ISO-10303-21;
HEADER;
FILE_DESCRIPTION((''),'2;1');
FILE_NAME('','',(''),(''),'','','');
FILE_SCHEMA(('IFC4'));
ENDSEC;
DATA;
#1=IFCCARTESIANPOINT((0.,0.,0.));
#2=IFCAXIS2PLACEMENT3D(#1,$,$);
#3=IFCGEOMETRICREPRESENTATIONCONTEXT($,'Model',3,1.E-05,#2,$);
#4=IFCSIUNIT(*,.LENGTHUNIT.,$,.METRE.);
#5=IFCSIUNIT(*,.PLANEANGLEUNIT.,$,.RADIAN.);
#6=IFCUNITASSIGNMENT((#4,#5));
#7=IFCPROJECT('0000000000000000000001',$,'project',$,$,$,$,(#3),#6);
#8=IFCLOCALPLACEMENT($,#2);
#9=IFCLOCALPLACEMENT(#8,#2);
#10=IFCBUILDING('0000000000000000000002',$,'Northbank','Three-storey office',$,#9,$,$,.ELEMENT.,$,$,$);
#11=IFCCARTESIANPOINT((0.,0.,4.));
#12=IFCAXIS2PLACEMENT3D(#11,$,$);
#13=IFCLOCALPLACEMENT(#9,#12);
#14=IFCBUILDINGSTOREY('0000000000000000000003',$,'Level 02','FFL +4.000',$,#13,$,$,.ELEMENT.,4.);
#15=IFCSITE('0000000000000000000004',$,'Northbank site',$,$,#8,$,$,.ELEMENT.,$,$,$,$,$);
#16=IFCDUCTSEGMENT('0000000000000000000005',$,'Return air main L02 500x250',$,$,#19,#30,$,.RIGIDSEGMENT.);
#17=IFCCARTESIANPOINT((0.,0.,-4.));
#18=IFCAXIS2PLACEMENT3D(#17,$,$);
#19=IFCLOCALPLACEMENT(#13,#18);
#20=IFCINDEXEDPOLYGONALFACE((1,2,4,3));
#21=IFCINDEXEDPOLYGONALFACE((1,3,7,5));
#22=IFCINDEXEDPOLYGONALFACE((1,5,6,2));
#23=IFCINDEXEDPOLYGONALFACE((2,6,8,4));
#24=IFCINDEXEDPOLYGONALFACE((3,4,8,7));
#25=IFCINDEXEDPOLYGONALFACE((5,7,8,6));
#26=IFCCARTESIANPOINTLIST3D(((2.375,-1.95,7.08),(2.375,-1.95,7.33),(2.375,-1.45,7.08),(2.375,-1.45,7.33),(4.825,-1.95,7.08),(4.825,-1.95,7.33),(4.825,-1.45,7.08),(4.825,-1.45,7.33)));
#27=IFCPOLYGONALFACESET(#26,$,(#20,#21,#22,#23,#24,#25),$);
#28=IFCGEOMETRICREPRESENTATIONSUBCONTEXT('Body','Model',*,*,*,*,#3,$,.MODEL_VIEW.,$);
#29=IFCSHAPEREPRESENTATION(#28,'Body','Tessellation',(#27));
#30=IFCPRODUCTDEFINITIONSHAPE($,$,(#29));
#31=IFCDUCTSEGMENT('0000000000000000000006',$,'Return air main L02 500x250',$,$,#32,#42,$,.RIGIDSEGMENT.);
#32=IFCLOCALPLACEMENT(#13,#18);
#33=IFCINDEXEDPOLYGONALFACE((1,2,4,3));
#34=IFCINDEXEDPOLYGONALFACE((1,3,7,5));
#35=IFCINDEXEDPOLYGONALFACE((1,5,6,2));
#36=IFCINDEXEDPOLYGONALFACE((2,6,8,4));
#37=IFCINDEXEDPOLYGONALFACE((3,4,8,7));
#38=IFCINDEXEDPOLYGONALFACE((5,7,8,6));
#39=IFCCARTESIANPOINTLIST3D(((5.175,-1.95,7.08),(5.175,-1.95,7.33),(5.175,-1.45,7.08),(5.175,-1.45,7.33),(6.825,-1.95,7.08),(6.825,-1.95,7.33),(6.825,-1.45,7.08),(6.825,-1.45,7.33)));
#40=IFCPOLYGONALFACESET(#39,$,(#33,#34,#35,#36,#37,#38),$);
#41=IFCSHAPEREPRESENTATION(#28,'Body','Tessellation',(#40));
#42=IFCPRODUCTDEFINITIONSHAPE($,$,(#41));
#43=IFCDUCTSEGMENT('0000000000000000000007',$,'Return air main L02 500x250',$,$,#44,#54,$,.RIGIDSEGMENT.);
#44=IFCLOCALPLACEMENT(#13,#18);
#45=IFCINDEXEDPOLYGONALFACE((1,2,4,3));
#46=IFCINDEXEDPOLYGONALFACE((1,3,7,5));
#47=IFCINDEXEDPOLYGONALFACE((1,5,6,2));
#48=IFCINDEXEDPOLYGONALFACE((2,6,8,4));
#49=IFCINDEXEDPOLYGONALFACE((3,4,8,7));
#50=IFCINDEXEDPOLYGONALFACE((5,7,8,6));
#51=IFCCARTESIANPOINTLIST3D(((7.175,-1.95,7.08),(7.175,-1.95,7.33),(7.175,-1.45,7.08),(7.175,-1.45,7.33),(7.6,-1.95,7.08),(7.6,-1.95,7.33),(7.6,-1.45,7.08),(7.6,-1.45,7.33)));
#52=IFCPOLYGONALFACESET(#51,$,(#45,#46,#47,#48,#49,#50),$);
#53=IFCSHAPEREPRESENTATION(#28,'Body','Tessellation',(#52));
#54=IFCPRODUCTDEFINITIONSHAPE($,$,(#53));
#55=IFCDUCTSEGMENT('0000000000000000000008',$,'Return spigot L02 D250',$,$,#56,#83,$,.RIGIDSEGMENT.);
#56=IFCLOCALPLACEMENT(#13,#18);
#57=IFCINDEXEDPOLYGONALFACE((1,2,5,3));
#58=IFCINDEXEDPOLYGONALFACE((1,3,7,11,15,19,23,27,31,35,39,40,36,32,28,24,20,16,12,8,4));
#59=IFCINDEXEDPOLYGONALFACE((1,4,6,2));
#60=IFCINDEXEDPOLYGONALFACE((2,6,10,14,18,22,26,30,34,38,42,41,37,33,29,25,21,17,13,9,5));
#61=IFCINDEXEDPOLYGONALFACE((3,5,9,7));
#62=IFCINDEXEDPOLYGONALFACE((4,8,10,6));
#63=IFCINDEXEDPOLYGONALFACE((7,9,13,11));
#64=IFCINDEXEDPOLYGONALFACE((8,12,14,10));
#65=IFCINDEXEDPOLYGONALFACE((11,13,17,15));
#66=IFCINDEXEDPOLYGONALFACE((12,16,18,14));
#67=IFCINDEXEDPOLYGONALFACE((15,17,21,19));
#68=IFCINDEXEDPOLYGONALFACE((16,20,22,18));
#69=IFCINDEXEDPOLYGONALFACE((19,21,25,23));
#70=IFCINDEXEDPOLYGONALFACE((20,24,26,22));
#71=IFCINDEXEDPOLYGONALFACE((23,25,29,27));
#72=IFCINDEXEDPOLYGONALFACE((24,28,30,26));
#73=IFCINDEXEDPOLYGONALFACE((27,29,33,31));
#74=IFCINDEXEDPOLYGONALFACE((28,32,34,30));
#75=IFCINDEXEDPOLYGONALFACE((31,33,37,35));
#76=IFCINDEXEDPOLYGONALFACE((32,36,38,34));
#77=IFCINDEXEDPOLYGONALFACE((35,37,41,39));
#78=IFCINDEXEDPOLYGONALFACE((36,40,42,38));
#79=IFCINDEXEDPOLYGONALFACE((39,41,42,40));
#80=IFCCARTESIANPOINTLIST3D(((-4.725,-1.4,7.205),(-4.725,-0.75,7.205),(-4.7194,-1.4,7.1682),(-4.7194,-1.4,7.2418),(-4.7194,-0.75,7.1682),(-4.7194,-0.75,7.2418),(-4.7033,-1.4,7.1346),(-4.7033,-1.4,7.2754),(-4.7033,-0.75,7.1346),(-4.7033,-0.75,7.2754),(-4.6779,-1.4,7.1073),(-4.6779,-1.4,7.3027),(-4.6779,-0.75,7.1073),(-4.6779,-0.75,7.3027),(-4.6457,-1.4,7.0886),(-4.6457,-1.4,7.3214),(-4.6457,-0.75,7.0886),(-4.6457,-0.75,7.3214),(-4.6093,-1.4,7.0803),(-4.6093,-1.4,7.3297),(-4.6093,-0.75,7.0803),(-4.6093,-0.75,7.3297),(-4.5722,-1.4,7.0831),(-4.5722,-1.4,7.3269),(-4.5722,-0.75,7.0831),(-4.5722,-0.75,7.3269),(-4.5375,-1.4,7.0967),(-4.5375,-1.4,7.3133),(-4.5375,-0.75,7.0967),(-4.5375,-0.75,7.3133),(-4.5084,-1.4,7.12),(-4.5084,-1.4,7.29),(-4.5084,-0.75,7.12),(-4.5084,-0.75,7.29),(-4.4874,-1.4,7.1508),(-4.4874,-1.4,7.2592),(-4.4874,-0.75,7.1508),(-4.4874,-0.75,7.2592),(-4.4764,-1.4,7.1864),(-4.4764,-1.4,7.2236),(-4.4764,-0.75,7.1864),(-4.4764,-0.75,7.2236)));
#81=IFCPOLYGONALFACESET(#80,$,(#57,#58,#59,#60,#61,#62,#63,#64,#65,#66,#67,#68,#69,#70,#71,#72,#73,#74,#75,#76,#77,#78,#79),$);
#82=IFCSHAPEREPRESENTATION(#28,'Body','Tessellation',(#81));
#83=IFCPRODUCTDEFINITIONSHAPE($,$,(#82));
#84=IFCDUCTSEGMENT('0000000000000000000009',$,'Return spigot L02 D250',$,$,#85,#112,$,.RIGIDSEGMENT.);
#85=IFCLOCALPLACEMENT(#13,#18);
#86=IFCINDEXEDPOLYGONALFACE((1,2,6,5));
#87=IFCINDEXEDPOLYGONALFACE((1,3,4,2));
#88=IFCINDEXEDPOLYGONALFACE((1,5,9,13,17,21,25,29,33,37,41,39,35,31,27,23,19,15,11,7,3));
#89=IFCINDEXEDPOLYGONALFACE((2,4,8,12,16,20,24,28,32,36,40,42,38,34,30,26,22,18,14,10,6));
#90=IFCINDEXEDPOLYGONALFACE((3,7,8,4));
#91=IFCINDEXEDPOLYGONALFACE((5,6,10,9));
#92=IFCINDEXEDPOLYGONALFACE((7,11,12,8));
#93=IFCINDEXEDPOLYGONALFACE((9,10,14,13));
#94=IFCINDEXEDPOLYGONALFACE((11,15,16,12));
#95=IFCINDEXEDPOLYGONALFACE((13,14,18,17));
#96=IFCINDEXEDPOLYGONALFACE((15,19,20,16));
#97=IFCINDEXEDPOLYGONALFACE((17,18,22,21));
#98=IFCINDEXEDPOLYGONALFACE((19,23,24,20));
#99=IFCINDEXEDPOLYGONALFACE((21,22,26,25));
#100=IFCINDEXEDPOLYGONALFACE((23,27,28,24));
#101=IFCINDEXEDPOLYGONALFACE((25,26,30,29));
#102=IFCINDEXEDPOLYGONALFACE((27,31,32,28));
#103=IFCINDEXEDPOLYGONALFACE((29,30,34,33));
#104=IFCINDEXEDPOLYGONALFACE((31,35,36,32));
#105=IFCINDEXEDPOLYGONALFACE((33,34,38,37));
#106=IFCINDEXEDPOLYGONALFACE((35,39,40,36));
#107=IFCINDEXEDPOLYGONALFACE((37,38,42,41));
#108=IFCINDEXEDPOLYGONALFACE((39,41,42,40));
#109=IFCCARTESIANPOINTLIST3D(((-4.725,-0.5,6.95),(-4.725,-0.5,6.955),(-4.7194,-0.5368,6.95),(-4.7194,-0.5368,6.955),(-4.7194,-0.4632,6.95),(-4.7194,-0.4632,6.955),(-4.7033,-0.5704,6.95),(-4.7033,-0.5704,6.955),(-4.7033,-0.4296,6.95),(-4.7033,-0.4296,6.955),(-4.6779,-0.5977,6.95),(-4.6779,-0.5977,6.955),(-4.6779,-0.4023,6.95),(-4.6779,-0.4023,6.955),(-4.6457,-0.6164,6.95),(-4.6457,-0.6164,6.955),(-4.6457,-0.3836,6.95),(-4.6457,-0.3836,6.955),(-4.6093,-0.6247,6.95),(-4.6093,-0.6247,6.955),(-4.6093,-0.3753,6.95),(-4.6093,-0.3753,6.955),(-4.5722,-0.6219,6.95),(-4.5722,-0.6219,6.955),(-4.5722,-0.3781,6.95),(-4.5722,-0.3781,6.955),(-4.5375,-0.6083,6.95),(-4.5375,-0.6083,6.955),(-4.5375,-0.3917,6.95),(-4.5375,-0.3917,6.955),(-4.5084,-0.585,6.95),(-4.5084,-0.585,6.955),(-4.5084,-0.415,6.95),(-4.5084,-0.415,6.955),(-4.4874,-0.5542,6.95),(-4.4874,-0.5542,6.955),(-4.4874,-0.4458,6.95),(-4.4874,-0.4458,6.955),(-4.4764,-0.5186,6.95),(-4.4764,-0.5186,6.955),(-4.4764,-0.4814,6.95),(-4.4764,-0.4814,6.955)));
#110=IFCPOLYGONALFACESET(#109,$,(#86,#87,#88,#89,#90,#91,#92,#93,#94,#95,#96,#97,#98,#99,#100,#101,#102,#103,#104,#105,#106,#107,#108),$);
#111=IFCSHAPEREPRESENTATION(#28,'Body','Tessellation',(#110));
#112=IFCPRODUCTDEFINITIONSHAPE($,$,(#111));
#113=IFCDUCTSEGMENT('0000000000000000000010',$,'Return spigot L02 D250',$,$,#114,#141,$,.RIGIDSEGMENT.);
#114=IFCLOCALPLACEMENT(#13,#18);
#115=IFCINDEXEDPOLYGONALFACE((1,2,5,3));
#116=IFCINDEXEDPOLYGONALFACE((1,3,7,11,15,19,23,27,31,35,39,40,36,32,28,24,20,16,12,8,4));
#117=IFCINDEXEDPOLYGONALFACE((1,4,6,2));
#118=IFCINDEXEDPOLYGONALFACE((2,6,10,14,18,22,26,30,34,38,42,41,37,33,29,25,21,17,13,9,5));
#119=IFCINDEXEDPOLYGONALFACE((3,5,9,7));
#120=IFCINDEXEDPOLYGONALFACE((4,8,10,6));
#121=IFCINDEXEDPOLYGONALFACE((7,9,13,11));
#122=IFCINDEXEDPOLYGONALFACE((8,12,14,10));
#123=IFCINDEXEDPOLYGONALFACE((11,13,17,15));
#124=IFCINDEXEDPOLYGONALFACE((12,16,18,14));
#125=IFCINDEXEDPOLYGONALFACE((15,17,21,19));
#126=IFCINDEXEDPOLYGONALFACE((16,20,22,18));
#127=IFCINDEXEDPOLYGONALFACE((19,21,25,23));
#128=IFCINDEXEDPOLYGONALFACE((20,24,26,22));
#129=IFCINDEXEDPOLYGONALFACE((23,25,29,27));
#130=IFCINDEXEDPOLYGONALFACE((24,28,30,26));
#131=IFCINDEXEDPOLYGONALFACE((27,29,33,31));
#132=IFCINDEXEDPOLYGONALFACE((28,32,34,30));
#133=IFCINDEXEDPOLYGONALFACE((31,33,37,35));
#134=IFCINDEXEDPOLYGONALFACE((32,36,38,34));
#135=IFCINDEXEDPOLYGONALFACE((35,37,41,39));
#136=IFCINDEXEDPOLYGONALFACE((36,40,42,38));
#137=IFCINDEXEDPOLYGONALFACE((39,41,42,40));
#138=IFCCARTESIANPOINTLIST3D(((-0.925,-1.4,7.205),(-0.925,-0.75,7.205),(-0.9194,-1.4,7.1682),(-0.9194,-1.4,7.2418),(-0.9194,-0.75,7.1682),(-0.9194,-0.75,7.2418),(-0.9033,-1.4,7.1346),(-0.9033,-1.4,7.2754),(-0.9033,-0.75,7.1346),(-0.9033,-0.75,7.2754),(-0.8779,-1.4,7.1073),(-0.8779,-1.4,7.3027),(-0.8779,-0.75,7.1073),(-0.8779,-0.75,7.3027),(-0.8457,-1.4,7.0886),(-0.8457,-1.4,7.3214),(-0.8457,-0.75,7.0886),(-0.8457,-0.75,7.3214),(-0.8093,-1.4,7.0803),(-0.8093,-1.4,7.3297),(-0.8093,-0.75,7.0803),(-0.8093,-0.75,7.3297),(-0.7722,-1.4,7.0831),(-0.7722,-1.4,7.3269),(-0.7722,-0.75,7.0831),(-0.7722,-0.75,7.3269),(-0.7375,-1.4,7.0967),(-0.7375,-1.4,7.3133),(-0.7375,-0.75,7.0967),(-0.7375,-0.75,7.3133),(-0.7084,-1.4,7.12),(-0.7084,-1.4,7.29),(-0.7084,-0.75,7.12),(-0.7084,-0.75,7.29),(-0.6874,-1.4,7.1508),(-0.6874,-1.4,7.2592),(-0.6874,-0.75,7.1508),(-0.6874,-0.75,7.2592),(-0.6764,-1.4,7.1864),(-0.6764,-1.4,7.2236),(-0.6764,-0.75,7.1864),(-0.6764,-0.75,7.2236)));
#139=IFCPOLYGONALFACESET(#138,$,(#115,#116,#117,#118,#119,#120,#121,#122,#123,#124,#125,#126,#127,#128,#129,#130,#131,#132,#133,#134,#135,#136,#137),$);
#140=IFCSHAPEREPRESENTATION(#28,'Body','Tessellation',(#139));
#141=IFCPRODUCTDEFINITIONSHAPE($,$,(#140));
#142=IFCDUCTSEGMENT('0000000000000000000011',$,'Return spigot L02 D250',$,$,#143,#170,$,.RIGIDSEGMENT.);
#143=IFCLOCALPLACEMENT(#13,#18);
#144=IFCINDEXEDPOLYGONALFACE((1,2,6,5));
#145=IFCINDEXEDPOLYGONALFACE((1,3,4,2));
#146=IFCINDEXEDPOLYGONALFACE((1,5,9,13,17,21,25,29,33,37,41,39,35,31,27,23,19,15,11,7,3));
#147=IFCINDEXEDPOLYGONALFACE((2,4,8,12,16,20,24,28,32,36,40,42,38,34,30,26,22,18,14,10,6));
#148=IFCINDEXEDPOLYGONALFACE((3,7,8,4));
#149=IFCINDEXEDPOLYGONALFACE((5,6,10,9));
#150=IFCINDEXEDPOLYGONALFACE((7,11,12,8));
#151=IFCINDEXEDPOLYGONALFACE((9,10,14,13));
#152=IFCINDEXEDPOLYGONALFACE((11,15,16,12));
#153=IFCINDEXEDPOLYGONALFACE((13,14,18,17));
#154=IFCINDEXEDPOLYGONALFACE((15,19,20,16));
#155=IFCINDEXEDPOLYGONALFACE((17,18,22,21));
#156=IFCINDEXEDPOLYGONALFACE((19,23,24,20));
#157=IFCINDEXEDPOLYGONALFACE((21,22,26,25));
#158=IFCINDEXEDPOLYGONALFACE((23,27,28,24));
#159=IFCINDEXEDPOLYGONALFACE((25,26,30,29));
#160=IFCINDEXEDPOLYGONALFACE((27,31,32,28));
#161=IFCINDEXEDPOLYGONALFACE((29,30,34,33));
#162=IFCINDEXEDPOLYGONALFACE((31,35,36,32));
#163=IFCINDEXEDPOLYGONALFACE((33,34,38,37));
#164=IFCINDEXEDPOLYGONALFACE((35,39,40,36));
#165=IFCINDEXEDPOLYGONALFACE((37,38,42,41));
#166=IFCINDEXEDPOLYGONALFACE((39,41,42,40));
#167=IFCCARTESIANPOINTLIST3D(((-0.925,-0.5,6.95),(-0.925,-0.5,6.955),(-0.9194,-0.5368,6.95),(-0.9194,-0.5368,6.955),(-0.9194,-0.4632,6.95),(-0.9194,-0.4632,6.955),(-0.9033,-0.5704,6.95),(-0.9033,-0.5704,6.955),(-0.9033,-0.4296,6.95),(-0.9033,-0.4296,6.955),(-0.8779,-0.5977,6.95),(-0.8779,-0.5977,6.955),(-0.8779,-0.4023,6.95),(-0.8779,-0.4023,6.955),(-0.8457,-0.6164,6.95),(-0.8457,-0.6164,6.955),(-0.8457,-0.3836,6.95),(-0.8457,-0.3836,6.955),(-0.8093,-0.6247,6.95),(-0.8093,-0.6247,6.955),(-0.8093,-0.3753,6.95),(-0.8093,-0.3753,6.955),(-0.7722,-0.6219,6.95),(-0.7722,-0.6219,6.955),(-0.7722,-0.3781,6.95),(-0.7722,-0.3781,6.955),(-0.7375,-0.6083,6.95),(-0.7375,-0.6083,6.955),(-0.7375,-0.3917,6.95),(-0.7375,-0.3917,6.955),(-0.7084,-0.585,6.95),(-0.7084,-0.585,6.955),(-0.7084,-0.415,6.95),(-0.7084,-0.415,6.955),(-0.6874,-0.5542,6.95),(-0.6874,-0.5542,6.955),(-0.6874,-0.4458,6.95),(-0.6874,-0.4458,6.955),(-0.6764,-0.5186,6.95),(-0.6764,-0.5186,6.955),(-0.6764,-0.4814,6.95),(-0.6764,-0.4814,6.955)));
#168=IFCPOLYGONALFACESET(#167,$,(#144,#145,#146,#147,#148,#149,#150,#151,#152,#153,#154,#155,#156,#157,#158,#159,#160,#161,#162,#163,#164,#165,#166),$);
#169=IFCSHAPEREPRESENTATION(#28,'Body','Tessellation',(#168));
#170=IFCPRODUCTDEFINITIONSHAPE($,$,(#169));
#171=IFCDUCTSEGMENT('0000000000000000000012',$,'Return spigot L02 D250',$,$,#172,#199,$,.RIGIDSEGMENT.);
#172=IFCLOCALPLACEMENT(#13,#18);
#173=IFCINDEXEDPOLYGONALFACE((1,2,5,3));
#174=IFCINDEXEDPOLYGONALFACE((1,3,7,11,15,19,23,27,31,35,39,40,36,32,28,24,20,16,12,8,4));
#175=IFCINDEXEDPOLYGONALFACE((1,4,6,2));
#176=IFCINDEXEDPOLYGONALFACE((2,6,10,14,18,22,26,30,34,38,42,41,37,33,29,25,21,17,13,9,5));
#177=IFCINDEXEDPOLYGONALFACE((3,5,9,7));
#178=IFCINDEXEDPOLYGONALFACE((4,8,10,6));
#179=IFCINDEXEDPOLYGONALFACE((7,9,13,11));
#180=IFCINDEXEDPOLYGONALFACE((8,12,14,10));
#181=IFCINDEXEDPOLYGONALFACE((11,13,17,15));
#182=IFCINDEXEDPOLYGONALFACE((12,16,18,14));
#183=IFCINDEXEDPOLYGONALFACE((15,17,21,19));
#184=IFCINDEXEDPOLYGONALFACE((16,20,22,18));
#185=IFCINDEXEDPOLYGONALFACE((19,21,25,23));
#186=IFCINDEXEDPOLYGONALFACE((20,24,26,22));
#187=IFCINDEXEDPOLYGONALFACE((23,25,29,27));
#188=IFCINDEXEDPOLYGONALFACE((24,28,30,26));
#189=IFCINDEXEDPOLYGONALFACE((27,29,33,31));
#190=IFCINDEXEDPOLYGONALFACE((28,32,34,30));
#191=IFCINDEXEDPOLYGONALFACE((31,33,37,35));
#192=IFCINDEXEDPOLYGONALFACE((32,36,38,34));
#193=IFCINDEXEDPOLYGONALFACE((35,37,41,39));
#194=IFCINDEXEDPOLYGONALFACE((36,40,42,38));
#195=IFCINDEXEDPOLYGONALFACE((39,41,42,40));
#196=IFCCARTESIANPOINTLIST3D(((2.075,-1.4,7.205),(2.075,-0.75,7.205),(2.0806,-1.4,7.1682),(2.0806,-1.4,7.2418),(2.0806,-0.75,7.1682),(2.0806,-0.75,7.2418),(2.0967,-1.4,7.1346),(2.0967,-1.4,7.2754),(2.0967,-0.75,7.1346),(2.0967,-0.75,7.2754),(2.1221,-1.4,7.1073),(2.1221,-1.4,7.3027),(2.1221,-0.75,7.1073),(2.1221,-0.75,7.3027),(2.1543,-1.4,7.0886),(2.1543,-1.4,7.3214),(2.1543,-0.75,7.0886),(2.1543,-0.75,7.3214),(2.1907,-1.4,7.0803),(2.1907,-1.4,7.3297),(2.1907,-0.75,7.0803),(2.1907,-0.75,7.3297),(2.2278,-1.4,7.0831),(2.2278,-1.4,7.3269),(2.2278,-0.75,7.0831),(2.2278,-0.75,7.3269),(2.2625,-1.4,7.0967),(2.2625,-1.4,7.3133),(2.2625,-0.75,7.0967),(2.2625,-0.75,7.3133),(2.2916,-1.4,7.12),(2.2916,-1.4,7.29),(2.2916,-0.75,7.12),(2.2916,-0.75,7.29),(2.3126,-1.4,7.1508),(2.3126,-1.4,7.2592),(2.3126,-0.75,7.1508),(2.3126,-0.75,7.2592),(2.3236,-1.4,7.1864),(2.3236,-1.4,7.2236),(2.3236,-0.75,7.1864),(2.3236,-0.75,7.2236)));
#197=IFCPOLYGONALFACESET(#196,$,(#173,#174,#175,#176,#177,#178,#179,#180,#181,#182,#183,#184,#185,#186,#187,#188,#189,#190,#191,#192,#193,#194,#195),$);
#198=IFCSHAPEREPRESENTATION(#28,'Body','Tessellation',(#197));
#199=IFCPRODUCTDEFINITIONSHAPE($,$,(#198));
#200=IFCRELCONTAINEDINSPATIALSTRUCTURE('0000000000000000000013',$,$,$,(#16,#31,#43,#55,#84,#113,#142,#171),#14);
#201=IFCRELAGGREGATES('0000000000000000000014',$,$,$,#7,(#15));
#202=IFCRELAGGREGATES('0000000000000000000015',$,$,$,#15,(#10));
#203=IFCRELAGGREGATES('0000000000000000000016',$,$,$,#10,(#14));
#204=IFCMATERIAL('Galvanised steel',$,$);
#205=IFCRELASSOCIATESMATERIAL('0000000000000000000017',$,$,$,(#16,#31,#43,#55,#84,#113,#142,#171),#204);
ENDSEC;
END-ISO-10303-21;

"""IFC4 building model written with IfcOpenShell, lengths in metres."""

from ifc_helpers import new_model, si_unit, frame, origin, place, context, subcontext, project, spatial, rectangle, circle, extrude, material, element, save


model = new_model("IFC4")

# Units and contexts
model_context = context("Model", 3, precision=1e-05, world=origin())
body_context = subcontext(model_context, "Body", "Model", "MODEL_VIEW")
ifc_project = project(units=[si_unit("LENGTHUNIT", "METRE"), si_unit("PLANEANGLEUNIT", "RADIAN")], contexts=[model_context])

# Site, building, storey
site_placement = place(None, origin())
site = spatial("IfcSite", under=ifc_project, at=site_placement, Name="Northbank site", CompositionType="ELEMENT")
building_placement = place(site_placement, origin())
building = spatial("IfcBuilding", under=site, at=building_placement, Name="Northbank", Description="Three-storey office", CompositionType="ELEMENT")
storey_placement = place(building_placement, frame((0.0, 0.0, 4.0)))
storey = spatial("IfcBuildingStorey", under=building, at=storey_placement, Name="Level 02", Description="FFL +4.000", CompositionType="ELEMENT", Elevation=4.0)

# Shared definitions
ifc_material_1 = material(Name="Galvanised steel")

# Duct segment
duct_segment_1_placement = place(storey_placement, frame((0.0, 0.0, -4.0)))
element("IfcDuctSegment", 1, at=duct_segment_1_placement, inside=storey, material=ifc_material_1, Name="Return air main L02 500x250", PredefinedType="RIGIDSEGMENT", context=body_context, shape_type="SweptSolid", body=[
    extrude(rectangle(XDim=0.5, YDim=0.25), frame((2.375, -1.7, 7.205), z_axis=(1.0, 0.0, 0.0), x_axis=(0.0, 1.0, 0.0)), (0.0, 0.0, 1.0), 2.45),
])

# Duct segments
duct_segment_2_placement = place(storey_placement, frame((0.0, 0.0, -4.0)))
element("IfcDuctSegment", 2, at=duct_segment_2_placement, inside=storey, material=ifc_material_1, Name="Return air main L02 500x250", PredefinedType="RIGIDSEGMENT", context=body_context, shape_type="SweptSolid", body=[
    extrude(rectangle(XDim=0.5, YDim=0.25), frame((5.175, -1.7, 7.205), z_axis=(1.0, 0.0, 0.0), x_axis=(0.0, 1.0, 0.0)), (0.0, 0.0, 1.0), 1.65),
])
duct_segment_3_placement = place(storey_placement, frame((0.0, 0.0, -4.0)))
element("IfcDuctSegment", 3, at=duct_segment_3_placement, inside=storey, material=ifc_material_1, Name="Return air main L02 500x250", PredefinedType="RIGIDSEGMENT", context=body_context, shape_type="SweptSolid", body=[
    extrude(rectangle(XDim=0.5, YDim=0.25), frame((7.175, -1.7, 7.205), z_axis=(1.0, 0.0, 0.0), x_axis=(0.0, 1.0, 0.0)), (0.0, 0.0, 1.0), 0.425),
])

# Duct segments
duct_segment_4_placement = place(storey_placement, frame((0.0, 0.0, -4.0)))
element("IfcDuctSegment", 4, at=duct_segment_4_placement, inside=storey, material=ifc_material_1, Name="Return spigot L02 D250", PredefinedType="RIGIDSEGMENT", context=body_context, shape_type="SweptSolid", body=[
    extrude(circle(Radius=0.125), frame((-4.6, -1.4, 7.205), z_axis=(0.0, 1.0, 0.0), x_axis=(-1.0, 0.0, 0.0)), (0.0, 0.0, 1.0), 0.65),
])
duct_segment_5_placement = place(storey_placement, frame((0.0, 0.0, -4.0)))
element("IfcDuctSegment", 5, at=duct_segment_5_placement, inside=storey, material=ifc_material_1, Name="Return spigot L02 D250", PredefinedType="RIGIDSEGMENT", context=body_context, shape_type="SweptSolid", body=[
    extrude(circle(Radius=0.125), frame((-4.6, -0.5, 6.955), z_axis=(0.0, 0.0, -1.0), x_axis=(-1.0, 0.0, 0.0)), (0.0, 0.0, 1.0), 0.005),
])

# Duct segments
duct_segment_6_placement = place(storey_placement, frame((0.0, 0.0, -4.0)))
element("IfcDuctSegment", 6, at=duct_segment_6_placement, inside=storey, material=ifc_material_1, Name="Return spigot L02 D250", PredefinedType="RIGIDSEGMENT", context=body_context, shape_type="SweptSolid", body=[
    extrude(circle(Radius=0.125), frame((-0.8, -1.4, 7.205), z_axis=(0.0, 1.0, 0.0), x_axis=(-1.0, 0.0, 0.0)), (0.0, 0.0, 1.0), 0.65),
])
duct_segment_7_placement = place(storey_placement, frame((0.0, 0.0, -4.0)))
element("IfcDuctSegment", 7, at=duct_segment_7_placement, inside=storey, material=ifc_material_1, Name="Return spigot L02 D250", PredefinedType="RIGIDSEGMENT", context=body_context, shape_type="SweptSolid", body=[
    extrude(circle(Radius=0.125), frame((-0.8, -0.5, 6.955), z_axis=(0.0, 0.0, -1.0), x_axis=(-1.0, 0.0, 0.0)), (0.0, 0.0, 1.0), 0.005),
])

# Duct segment
duct_segment_8_placement = place(storey_placement, frame((0.0, 0.0, -4.0)))
element("IfcDuctSegment", 8, at=duct_segment_8_placement, inside=storey, material=ifc_material_1, Name="Return spigot L02 D250", PredefinedType="RIGIDSEGMENT", context=body_context, shape_type="SweptSolid", body=[
    extrude(circle(Radius=0.125), frame((2.2, -1.4, 7.205), z_axis=(0.0, 1.0, 0.0), x_axis=(-1.0, 0.0, 0.0)), (0.0, 0.0, 1.0), 0.65),
])

save(model, "model.ifc")
